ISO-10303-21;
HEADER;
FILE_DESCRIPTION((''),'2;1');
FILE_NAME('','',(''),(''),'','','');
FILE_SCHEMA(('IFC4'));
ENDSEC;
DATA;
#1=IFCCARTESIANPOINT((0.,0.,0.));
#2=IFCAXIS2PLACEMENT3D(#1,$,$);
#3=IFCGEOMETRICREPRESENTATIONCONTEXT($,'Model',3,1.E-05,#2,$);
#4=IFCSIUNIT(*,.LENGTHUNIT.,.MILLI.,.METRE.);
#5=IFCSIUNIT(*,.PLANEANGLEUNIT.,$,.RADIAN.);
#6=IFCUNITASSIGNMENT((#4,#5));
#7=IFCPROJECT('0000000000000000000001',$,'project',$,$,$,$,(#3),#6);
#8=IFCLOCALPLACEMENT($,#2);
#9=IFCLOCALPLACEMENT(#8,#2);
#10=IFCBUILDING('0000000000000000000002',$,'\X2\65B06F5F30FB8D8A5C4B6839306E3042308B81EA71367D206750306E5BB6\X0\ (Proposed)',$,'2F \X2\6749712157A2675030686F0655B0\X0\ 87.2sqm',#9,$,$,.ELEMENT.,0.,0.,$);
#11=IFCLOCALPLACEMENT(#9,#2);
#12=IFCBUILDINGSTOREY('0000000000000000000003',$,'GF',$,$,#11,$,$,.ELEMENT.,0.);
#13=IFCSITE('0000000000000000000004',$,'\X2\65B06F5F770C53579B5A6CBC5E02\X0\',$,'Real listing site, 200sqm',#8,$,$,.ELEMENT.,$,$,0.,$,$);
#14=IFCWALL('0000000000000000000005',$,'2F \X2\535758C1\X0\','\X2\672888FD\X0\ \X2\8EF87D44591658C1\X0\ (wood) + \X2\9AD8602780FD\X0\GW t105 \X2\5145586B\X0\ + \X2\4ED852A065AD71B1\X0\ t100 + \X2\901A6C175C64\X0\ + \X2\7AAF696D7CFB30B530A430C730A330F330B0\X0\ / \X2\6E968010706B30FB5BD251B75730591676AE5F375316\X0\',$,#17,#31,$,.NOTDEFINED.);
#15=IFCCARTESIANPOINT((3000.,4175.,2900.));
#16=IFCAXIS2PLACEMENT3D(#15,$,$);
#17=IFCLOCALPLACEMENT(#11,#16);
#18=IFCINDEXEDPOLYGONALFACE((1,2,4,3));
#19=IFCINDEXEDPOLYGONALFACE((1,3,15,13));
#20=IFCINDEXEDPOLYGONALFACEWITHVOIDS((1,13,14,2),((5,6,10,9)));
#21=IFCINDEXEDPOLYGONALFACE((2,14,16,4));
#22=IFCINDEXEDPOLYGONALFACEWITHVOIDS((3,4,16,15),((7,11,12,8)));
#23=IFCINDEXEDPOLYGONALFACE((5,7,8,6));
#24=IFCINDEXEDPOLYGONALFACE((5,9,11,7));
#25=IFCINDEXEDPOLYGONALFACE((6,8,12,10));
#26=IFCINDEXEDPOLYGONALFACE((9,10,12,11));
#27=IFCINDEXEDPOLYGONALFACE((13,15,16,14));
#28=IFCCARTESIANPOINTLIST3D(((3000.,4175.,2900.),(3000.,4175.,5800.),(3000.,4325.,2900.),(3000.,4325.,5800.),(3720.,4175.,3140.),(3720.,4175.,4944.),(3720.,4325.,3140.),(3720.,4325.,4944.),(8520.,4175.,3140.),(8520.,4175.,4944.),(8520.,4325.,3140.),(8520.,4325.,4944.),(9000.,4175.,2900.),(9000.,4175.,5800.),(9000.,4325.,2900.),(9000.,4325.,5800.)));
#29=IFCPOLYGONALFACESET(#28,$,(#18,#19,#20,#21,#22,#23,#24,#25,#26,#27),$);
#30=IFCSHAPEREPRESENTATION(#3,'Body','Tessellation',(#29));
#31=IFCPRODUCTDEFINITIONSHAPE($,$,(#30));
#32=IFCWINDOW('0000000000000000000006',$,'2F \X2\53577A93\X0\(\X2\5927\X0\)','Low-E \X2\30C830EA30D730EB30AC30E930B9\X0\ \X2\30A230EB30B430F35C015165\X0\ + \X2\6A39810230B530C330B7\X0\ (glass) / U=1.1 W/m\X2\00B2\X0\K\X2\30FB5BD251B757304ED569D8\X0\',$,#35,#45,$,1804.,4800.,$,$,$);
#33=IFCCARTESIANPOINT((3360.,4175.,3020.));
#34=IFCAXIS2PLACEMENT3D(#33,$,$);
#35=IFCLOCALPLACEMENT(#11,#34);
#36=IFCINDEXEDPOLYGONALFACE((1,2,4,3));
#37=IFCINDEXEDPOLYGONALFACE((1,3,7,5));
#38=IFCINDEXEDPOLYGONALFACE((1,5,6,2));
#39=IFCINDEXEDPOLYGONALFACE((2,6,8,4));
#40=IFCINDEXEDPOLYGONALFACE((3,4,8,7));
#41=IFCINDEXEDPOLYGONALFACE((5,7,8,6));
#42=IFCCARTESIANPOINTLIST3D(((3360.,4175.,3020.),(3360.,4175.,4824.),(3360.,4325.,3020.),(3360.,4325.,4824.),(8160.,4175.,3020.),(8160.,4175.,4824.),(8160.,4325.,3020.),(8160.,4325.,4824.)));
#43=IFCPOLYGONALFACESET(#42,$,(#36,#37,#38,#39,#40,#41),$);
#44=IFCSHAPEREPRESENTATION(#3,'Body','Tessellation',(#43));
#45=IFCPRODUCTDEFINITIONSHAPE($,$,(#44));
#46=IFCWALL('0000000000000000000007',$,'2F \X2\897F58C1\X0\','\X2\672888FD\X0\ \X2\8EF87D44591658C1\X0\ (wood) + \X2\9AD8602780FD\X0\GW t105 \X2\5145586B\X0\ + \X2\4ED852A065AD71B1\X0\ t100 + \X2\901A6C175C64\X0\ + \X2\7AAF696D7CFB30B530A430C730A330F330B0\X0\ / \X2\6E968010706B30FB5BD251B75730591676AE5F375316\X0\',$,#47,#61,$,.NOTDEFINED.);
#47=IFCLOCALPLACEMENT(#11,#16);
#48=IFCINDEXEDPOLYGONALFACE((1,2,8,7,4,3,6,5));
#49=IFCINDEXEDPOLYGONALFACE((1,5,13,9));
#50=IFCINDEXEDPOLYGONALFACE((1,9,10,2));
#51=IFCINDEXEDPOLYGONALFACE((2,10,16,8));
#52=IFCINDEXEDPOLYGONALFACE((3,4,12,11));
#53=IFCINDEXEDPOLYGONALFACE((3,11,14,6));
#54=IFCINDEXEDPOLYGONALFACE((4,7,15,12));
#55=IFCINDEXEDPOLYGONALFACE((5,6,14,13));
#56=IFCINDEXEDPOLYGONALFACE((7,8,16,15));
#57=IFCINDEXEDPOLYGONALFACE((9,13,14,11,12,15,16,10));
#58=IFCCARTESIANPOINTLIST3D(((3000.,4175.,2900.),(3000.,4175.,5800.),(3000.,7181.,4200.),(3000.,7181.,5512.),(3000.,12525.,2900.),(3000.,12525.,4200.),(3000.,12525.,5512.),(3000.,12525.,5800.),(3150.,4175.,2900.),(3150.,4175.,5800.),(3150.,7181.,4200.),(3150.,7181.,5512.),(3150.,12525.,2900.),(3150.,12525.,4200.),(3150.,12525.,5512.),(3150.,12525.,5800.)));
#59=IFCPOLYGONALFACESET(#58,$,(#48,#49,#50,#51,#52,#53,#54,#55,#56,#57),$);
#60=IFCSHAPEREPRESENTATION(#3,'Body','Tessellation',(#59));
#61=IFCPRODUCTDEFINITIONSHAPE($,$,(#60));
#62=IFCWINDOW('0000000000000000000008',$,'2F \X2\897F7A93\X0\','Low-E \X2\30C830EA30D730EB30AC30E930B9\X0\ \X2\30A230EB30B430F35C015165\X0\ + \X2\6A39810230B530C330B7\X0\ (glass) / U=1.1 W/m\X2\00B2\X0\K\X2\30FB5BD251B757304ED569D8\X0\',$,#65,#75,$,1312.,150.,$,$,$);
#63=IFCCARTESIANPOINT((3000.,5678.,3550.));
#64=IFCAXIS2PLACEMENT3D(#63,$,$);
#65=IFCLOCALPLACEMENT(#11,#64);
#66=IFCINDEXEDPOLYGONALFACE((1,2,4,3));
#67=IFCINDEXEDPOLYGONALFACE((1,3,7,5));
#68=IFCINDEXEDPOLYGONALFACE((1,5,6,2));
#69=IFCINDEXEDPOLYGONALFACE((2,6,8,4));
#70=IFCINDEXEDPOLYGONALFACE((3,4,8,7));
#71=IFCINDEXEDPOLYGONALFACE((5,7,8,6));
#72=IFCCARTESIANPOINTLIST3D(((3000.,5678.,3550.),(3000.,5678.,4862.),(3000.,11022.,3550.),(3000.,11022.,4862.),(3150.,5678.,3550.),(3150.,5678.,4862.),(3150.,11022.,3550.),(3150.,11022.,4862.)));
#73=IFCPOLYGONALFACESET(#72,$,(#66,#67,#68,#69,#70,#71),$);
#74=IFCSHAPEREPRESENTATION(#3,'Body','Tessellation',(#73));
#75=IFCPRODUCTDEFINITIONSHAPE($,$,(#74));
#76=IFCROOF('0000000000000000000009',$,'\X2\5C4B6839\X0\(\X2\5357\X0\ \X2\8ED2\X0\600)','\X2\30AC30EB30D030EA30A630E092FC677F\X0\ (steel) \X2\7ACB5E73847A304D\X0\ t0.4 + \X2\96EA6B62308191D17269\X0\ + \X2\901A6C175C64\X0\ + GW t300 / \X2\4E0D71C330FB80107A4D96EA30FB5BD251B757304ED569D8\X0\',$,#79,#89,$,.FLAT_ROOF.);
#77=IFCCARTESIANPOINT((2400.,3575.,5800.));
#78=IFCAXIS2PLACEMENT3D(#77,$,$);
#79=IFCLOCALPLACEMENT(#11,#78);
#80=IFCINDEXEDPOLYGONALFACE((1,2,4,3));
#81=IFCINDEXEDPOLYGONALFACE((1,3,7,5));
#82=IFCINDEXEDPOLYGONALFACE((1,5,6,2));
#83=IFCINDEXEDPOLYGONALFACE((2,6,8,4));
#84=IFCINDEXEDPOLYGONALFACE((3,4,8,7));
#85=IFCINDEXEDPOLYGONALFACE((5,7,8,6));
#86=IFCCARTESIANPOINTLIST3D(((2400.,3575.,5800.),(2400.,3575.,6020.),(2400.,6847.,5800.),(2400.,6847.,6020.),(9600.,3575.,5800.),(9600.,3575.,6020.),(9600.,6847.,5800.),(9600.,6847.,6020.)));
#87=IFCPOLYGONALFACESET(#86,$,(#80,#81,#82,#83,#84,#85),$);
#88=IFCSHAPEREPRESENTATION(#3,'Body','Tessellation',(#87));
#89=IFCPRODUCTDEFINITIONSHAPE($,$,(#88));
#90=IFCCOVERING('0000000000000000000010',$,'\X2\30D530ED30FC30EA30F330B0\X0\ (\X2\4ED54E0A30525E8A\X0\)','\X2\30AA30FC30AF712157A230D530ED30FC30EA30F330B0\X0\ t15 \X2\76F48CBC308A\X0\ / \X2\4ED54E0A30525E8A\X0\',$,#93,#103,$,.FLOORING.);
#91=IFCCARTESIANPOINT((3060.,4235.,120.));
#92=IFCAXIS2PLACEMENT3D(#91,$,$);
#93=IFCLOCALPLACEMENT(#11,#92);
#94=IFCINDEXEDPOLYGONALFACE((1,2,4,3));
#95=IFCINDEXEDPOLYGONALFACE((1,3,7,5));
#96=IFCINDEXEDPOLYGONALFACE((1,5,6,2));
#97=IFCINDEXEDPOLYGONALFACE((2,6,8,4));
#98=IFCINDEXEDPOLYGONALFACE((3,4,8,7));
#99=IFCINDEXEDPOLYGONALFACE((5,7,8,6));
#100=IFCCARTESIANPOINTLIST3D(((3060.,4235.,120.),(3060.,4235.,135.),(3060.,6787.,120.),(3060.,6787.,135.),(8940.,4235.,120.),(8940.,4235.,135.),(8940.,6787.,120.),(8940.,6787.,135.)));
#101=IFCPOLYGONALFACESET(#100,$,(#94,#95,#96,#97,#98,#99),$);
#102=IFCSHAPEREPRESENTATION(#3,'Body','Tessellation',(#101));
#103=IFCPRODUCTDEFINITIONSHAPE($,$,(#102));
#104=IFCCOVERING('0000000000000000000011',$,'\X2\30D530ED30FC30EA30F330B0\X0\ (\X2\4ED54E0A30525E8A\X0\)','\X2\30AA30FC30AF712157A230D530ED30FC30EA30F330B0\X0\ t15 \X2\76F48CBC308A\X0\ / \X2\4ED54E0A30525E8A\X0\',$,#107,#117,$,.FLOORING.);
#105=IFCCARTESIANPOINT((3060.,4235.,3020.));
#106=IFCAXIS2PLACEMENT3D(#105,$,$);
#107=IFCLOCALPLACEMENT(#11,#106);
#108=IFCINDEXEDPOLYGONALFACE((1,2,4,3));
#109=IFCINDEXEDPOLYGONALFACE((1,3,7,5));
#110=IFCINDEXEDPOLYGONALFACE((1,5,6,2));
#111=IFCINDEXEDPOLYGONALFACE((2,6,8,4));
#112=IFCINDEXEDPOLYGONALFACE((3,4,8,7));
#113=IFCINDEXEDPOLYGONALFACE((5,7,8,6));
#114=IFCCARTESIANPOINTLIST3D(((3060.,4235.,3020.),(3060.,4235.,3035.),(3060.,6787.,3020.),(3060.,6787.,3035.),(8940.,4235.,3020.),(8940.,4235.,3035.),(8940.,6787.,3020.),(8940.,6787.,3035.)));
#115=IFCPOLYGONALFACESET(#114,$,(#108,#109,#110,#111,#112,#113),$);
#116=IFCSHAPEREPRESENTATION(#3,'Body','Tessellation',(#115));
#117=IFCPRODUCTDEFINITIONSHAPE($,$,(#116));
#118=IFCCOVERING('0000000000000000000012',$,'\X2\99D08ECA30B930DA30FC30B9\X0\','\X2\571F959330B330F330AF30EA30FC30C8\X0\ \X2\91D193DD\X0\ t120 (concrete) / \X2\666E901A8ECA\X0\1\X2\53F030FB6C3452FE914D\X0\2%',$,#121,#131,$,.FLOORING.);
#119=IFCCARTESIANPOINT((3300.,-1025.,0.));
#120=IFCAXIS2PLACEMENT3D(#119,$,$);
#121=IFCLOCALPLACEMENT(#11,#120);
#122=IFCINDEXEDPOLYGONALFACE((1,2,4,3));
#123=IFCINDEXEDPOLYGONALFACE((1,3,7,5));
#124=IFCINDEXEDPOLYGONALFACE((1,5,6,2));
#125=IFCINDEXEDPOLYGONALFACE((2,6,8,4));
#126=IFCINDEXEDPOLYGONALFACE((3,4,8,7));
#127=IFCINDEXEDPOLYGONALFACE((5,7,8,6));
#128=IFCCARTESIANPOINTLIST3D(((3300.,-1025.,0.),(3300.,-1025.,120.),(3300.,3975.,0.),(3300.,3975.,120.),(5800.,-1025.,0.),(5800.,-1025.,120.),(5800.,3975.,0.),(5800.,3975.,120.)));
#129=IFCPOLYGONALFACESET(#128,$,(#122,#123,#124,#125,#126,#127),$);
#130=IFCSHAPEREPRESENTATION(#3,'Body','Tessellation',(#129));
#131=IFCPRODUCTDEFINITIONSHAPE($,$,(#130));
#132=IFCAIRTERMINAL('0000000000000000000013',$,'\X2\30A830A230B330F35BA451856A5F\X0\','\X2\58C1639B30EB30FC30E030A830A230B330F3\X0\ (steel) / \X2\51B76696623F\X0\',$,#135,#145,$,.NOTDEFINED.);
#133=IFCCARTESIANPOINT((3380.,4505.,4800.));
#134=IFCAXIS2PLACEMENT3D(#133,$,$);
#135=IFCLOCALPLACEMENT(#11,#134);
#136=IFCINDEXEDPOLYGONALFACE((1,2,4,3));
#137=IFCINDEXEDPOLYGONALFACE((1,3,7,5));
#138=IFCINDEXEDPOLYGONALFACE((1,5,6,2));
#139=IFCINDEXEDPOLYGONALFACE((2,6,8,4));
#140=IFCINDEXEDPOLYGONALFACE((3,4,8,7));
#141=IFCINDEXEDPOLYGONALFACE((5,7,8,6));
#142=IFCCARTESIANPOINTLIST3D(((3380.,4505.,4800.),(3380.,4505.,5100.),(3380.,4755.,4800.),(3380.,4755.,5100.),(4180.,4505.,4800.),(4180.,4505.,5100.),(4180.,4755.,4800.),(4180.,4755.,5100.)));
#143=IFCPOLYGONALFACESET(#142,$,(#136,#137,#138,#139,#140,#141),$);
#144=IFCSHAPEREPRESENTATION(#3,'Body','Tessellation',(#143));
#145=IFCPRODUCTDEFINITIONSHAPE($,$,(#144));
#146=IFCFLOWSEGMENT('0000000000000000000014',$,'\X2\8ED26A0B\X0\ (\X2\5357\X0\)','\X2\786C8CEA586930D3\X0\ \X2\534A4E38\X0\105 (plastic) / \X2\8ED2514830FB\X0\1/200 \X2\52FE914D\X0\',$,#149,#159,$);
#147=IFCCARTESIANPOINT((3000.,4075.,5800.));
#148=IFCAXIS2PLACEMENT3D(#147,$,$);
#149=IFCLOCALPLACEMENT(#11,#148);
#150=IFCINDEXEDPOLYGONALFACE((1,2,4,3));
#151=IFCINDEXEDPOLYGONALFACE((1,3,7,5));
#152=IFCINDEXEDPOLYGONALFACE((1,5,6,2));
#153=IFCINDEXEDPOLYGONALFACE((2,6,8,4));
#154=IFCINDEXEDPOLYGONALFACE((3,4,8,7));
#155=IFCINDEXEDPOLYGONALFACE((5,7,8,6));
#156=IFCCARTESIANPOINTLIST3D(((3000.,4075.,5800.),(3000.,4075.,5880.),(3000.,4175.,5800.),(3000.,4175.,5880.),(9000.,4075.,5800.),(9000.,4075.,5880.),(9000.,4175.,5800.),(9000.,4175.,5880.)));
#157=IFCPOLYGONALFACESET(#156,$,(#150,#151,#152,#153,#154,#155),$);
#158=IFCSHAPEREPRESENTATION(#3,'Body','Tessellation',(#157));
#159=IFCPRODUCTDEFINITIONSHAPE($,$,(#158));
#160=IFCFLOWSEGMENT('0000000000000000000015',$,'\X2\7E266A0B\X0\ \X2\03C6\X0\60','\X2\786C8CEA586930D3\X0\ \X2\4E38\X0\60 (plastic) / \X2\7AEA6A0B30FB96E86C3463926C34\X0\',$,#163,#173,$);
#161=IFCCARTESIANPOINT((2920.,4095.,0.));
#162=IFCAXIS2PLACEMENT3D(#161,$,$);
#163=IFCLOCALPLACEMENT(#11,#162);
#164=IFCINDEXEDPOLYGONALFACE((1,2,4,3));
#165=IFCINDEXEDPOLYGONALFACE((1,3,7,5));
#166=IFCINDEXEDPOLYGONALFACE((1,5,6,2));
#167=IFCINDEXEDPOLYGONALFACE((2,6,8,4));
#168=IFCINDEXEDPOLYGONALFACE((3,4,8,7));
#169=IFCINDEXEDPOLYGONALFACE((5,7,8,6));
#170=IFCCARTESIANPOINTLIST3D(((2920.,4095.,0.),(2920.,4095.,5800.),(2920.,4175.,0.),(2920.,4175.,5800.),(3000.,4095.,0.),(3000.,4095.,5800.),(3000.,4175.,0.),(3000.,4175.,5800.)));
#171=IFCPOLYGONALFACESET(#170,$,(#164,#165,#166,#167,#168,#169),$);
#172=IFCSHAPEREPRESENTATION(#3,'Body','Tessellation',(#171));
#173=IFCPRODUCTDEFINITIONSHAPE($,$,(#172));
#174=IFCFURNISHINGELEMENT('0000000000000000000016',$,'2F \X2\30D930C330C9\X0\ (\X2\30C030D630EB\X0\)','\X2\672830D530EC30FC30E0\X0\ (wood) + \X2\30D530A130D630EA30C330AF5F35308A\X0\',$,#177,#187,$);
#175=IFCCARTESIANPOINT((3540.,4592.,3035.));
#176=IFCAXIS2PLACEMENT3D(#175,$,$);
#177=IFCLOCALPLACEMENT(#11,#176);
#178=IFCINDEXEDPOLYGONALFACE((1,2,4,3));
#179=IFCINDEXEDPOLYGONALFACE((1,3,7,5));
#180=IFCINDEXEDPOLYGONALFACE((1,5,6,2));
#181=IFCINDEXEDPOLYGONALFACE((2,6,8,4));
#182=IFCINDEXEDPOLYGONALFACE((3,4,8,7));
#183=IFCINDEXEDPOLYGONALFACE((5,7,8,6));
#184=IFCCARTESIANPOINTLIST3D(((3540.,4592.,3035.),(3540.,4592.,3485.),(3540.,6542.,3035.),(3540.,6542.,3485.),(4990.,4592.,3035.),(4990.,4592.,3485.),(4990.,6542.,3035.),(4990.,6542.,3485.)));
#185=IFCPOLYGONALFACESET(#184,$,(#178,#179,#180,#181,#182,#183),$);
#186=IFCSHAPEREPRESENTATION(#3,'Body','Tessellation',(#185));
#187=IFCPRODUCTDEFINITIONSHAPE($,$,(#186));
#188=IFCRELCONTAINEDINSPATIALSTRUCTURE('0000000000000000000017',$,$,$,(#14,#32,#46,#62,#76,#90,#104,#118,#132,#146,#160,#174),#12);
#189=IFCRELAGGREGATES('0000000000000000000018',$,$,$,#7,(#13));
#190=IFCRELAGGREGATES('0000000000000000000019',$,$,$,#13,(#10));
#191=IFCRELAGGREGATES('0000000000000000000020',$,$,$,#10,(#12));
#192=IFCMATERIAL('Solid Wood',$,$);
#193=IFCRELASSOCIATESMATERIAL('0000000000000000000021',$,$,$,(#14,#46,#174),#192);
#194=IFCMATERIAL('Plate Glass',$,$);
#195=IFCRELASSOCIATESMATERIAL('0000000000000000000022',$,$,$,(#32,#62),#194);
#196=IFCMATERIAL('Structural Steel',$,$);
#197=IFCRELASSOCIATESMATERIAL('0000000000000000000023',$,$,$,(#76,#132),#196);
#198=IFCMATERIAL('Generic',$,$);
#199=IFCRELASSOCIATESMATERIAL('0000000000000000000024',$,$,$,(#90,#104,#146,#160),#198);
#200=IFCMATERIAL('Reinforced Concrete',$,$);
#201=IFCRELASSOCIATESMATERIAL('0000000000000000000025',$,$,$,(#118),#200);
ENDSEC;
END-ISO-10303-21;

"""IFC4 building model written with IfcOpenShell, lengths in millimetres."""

from ifc_helpers import new_model, si_unit, frame, frame_2d, origin, place, context, project, spatial, rectangle, extrude, material, element, fill, save


model = new_model("IFC4")

# Units and contexts
model_context = context("Model", 3, precision=1e-05, world=origin())
ifc_project = project(units=[si_unit("LENGTHUNIT", "METRE", prefix="MILLI"), si_unit("PLANEANGLEUNIT", "RADIAN")], contexts=[model_context])

# Site, building, storey
site_placement = place(None, origin())
site = spatial("IfcSite", under=ifc_project, at=site_placement, Name="新潟県南魚沼市", ObjectType="Real listing site, 200sqm", CompositionType="ELEMENT", RefElevation=0.0)
building_placement = place(site_placement, origin())
building = spatial("IfcBuilding", under=site, at=building_placement, Name="新潟・越屋根のある自然素材の家 (Proposed)", ObjectType="2F 杉無垢材と漆喰 87.2sqm", CompositionType="ELEMENT", ElevationOfRefHeight=0.0, ElevationOfTerrain=0.0)
storey_placement = place(building_placement, origin())
storey = spatial("IfcBuildingStorey", under=building, at=storey_placement, Name="GF", CompositionType="ELEMENT", Elevation=0.0)

# Shared definitions
ifc_material_1 = material(Name="Solid Wood")

# Shared definitions
ifc_material_2 = material(Name="Reinforced Concrete")

# Shared definitions
ifc_material_3 = material(Name="Plate Glass")

# Walls, openings, windows
wall_1_placement = place(storey_placement, frame((3000.0, 4175.0, 2900.0)))
wall_1 = element("IfcWall", 1, at=wall_1_placement, inside=storey, material=ifc_material_1, Name="2F 南壁", Description="木製 軸組外壁 (wood) + 高性能GW t105 充填 + 付加断熱 t100 + 通気層 + 窯業系サイディング / 準耐火・寒冷地外皮強化", PredefinedType="NOTDEFINED", context=model_context, shape_type="SweptSolid", body=[
    extrude(rectangle(XDim=6000.0, YDim=150.0, at=frame_2d((3000.0, 75.0))), frame((3000.0, 4175.0, 2900.0)), (0.0, 0.0, 1.0), 2900.0),
])
opening_1_placement = place(storey_placement, frame((3360.0, 4175.0, 3020.0)))
opening_1 = element("IfcOpeningElement", 2, at=opening_1_placement, cuts=wall_1, PredefinedType="NOTDEFINED", context=model_context, shape_type="SweptSolid", body=[
    extrude(rectangle(XDim=4800.0, YDim=150.0, at=frame_2d((2400.0, 75.0))), frame((3360.0, 4175.0, 3020.0)), (0.0, 0.0, 1.0), 1804.0),
])
window_1_placement = place(storey_placement, frame((3360.0, 4175.0, 3020.0)))
window_1 = element("IfcWindow", 3, at=window_1_placement, inside=storey, material=ifc_material_3, Name="2F 南窓(大)", Description="Low-E トリプルガラス アルゴン封入 + 樹脂サッシ (glass) / U=1.1 W/m²K・寒冷地仕様", OverallHeight=1804.0, OverallWidth=4800.0, context=model_context, shape_type="SweptSolid", body=[
    extrude(rectangle(XDim=4800.0, YDim=150.0, at=frame_2d((2400.0, 75.0))), frame((3360.0, 4175.0, 3020.0)), (0.0, 0.0, 1.0), 1804.0),
])
fill(opening_1, window_1)
wall_2_placement = place(storey_placement, frame((3000.0, 4175.0, 2900.0)))
wall_2 = element("IfcWall", 4, at=wall_2_placement, inside=storey, material=ifc_material_1, Name="2F 西壁", Description="木製 軸組外壁 (wood) + 高性能GW t105 充填 + 付加断熱 t100 + 通気層 + 窯業系サイディング / 準耐火・寒冷地外皮強化", PredefinedType="NOTDEFINED", context=model_context, shape_type="SweptSolid", body=[
    extrude(rectangle(XDim=150.0, YDim=8350.0, at=frame_2d((75.0, 4175.0))), frame((3000.0, 4175.0, 2900.0)), (0.0, 0.0, 1.0), 2900.0),
])
opening_2_placement = place(storey_placement, frame((3000.0, 5678.0, 3550.0)))
opening_2 = element("IfcOpeningElement", 5, at=opening_2_placement, cuts=wall_2, PredefinedType="NOTDEFINED", context=model_context, shape_type="SweptSolid", body=[
    extrude(rectangle(XDim=150.0, YDim=5344.0, at=frame_2d((75.0, 2672.0))), frame((3000.0, 5678.0, 3550.0)), (0.0, 0.0, 1.0), 1312.0),
])
window_2_placement = place(storey_placement, frame((3000.0, 5678.0, 3550.0)))
window_2 = element("IfcWindow", 6, at=window_2_placement, inside=storey, material=ifc_material_3, Name="2F 西窓", Description="Low-E トリプルガラス アルゴン封入 + 樹脂サッシ (glass) / U=1.1 W/m²K・寒冷地仕様", OverallHeight=1312.0, OverallWidth=150.0, context=model_context, shape_type="SweptSolid", body=[
    extrude(rectangle(XDim=150.0, YDim=5344.0, at=frame_2d((75.0, 2672.0))), frame((3000.0, 5678.0, 3550.0)), (0.0, 0.0, 1.0), 1312.0),
])
fill(opening_2, window_2)

# Roof
ifc_material_4 = material(Name="Structural Steel")
for number, where, name in (
    (7, (2400.0, 3575.0, 5800.0), "屋根(南 軒600)"),
):
    element("IfcRoof", number, at=place(storey_placement, frame(where)), inside=storey, material=ifc_material_4, Name=name, Description="ガルバリウム鋼板 (steel) 立平葺き t0.4 + 雪止め金物 + 通気層 + GW t300 / 不燃・耐積雪・寒冷地仕様", PredefinedType="FLAT_ROOF", context=model_context, shape_type="SweptSolid", body=[
        extrude(rectangle(XDim=7200.0, YDim=3272.0, at=frame_2d((3600.0, 1636.0))), frame((2400.0, 3575.0, 5800.0)), (0.0, 0.0, 1.0), 220.0),
    ])

# Coverings
ifc_material_5 = material(Name="Generic")
covering_1_placement = place(storey_placement, frame((3060.0, 4235.0, 120.0)))
element("IfcCovering", 8, at=covering_1_placement, inside=storey, material=ifc_material_5, Name="フローリング (仕上げ床)", Description="オーク無垢フローリング t15 直貼り / 仕上げ床", PredefinedType="FLOORING", context=model_context, shape_type="SweptSolid", body=[
    extrude(rectangle(XDim=5880.0, YDim=2552.0, at=frame_2d((2940.0, 1276.0))), frame((3060.0, 4235.0, 120.0)), (0.0, 0.0, 1.0), 15.0),
])
covering_2_placement = place(storey_placement, frame((3060.0, 4235.0, 3020.0)))
element("IfcCovering", 9, at=covering_2_placement, inside=storey, material=ifc_material_5, Name="フローリング (仕上げ床)", Description="オーク無垢フローリング t15 直貼り / 仕上げ床", PredefinedType="FLOORING", context=model_context, shape_type="SweptSolid", body=[
    extrude(rectangle(XDim=5880.0, YDim=2552.0, at=frame_2d((2940.0, 1276.0))), frame((3060.0, 4235.0, 3020.0)), (0.0, 0.0, 1.0), 15.0),
])
covering_3_placement = place(storey_placement, frame((3300.0, -1025.0, 0.0)))
element("IfcCovering", 10, at=covering_3_placement, inside=storey, material=ifc_material_2, Name="駐車スペース", Description="土間コンクリート 金鏝 t120 (concrete) / 普通車1台・水勾配2%", PredefinedType="FLOORING", context=model_context, shape_type="SweptSolid", body=[
    extrude(rectangle(XDim=2500.0, YDim=5000.0, at=frame_2d((1250.0, 2500.0))), frame((3300.0, -1025.0, 0.0)), (0.0, 0.0, 1.0), 120.0),
])

# Air terminal
air_terminal_placement = place(storey_placement, frame((3380.0, 4505.0, 4800.0)))
element("IfcAirTerminal", 11, at=air_terminal_placement, inside=storey, material=ifc_material_4, Name="エアコン室内機", Description="壁掛ルームエアコン (steel) / 冷暖房", PredefinedType="NOTDEFINED", context=model_context, shape_type="SweptSolid", body=[
    extrude(rectangle(XDim=800.0, YDim=250.0, at=frame_2d((400.0, 125.0))), frame((3380.0, 4505.0, 4800.0)), (0.0, 0.0, 1.0), 300.0),
])

# Flow segments
flow_segment_1_placement = place(storey_placement, frame((3000.0, 4075.0, 5800.0)))
element("IfcFlowSegment", 12, at=flow_segment_1_placement, inside=storey, material=ifc_material_5, Name="軒樋 (南)", Description="硬質塩ビ 半丸105 (plastic) / 軒先・1/200 勾配", context=model_context, shape_type="SweptSolid", body=[
    extrude(rectangle(XDim=6000.0, YDim=100.0, at=frame_2d((3000.0, 50.0))), frame((3000.0, 4075.0, 5800.0)), (0.0, 0.0, 1.0), 80.0),
])
flow_segment_2_placement = place(storey_placement, frame((2920.0, 4095.0, 0.0)))
element("IfcFlowSegment", 13, at=flow_segment_2_placement, inside=storey, material=ifc_material_5, Name="縦樋 φ60", Description="硬質塩ビ 丸60 (plastic) / 竪樋・雨水排水", context=model_context, shape_type="SweptSolid", body=[
    extrude(rectangle(XDim=80.0, YDim=80.0, at=frame_2d((40.0, 40.0))), frame((2920.0, 4095.0, 0.0)), (0.0, 0.0, 1.0), 5800.0),
])

# Furnishing element
furnishing_placement = place(storey_placement, frame((3540.0, 4592.0, 3035.0)))
element("IfcFurnishingElement", 14, at=furnishing_placement, inside=storey, material=ifc_material_1, Name="2F ベッド (ダブル)", Description="木フレーム (wood) + ファブリック張り", context=model_context, shape_type="SweptSolid", body=[
    extrude(rectangle(XDim=1450.0, YDim=1950.0, at=frame_2d((725.0, 975.0))), frame((3540.0, 4592.0, 3035.0)), (0.0, 0.0, 1.0), 450.0),
])

save(model, "model.ifc")
